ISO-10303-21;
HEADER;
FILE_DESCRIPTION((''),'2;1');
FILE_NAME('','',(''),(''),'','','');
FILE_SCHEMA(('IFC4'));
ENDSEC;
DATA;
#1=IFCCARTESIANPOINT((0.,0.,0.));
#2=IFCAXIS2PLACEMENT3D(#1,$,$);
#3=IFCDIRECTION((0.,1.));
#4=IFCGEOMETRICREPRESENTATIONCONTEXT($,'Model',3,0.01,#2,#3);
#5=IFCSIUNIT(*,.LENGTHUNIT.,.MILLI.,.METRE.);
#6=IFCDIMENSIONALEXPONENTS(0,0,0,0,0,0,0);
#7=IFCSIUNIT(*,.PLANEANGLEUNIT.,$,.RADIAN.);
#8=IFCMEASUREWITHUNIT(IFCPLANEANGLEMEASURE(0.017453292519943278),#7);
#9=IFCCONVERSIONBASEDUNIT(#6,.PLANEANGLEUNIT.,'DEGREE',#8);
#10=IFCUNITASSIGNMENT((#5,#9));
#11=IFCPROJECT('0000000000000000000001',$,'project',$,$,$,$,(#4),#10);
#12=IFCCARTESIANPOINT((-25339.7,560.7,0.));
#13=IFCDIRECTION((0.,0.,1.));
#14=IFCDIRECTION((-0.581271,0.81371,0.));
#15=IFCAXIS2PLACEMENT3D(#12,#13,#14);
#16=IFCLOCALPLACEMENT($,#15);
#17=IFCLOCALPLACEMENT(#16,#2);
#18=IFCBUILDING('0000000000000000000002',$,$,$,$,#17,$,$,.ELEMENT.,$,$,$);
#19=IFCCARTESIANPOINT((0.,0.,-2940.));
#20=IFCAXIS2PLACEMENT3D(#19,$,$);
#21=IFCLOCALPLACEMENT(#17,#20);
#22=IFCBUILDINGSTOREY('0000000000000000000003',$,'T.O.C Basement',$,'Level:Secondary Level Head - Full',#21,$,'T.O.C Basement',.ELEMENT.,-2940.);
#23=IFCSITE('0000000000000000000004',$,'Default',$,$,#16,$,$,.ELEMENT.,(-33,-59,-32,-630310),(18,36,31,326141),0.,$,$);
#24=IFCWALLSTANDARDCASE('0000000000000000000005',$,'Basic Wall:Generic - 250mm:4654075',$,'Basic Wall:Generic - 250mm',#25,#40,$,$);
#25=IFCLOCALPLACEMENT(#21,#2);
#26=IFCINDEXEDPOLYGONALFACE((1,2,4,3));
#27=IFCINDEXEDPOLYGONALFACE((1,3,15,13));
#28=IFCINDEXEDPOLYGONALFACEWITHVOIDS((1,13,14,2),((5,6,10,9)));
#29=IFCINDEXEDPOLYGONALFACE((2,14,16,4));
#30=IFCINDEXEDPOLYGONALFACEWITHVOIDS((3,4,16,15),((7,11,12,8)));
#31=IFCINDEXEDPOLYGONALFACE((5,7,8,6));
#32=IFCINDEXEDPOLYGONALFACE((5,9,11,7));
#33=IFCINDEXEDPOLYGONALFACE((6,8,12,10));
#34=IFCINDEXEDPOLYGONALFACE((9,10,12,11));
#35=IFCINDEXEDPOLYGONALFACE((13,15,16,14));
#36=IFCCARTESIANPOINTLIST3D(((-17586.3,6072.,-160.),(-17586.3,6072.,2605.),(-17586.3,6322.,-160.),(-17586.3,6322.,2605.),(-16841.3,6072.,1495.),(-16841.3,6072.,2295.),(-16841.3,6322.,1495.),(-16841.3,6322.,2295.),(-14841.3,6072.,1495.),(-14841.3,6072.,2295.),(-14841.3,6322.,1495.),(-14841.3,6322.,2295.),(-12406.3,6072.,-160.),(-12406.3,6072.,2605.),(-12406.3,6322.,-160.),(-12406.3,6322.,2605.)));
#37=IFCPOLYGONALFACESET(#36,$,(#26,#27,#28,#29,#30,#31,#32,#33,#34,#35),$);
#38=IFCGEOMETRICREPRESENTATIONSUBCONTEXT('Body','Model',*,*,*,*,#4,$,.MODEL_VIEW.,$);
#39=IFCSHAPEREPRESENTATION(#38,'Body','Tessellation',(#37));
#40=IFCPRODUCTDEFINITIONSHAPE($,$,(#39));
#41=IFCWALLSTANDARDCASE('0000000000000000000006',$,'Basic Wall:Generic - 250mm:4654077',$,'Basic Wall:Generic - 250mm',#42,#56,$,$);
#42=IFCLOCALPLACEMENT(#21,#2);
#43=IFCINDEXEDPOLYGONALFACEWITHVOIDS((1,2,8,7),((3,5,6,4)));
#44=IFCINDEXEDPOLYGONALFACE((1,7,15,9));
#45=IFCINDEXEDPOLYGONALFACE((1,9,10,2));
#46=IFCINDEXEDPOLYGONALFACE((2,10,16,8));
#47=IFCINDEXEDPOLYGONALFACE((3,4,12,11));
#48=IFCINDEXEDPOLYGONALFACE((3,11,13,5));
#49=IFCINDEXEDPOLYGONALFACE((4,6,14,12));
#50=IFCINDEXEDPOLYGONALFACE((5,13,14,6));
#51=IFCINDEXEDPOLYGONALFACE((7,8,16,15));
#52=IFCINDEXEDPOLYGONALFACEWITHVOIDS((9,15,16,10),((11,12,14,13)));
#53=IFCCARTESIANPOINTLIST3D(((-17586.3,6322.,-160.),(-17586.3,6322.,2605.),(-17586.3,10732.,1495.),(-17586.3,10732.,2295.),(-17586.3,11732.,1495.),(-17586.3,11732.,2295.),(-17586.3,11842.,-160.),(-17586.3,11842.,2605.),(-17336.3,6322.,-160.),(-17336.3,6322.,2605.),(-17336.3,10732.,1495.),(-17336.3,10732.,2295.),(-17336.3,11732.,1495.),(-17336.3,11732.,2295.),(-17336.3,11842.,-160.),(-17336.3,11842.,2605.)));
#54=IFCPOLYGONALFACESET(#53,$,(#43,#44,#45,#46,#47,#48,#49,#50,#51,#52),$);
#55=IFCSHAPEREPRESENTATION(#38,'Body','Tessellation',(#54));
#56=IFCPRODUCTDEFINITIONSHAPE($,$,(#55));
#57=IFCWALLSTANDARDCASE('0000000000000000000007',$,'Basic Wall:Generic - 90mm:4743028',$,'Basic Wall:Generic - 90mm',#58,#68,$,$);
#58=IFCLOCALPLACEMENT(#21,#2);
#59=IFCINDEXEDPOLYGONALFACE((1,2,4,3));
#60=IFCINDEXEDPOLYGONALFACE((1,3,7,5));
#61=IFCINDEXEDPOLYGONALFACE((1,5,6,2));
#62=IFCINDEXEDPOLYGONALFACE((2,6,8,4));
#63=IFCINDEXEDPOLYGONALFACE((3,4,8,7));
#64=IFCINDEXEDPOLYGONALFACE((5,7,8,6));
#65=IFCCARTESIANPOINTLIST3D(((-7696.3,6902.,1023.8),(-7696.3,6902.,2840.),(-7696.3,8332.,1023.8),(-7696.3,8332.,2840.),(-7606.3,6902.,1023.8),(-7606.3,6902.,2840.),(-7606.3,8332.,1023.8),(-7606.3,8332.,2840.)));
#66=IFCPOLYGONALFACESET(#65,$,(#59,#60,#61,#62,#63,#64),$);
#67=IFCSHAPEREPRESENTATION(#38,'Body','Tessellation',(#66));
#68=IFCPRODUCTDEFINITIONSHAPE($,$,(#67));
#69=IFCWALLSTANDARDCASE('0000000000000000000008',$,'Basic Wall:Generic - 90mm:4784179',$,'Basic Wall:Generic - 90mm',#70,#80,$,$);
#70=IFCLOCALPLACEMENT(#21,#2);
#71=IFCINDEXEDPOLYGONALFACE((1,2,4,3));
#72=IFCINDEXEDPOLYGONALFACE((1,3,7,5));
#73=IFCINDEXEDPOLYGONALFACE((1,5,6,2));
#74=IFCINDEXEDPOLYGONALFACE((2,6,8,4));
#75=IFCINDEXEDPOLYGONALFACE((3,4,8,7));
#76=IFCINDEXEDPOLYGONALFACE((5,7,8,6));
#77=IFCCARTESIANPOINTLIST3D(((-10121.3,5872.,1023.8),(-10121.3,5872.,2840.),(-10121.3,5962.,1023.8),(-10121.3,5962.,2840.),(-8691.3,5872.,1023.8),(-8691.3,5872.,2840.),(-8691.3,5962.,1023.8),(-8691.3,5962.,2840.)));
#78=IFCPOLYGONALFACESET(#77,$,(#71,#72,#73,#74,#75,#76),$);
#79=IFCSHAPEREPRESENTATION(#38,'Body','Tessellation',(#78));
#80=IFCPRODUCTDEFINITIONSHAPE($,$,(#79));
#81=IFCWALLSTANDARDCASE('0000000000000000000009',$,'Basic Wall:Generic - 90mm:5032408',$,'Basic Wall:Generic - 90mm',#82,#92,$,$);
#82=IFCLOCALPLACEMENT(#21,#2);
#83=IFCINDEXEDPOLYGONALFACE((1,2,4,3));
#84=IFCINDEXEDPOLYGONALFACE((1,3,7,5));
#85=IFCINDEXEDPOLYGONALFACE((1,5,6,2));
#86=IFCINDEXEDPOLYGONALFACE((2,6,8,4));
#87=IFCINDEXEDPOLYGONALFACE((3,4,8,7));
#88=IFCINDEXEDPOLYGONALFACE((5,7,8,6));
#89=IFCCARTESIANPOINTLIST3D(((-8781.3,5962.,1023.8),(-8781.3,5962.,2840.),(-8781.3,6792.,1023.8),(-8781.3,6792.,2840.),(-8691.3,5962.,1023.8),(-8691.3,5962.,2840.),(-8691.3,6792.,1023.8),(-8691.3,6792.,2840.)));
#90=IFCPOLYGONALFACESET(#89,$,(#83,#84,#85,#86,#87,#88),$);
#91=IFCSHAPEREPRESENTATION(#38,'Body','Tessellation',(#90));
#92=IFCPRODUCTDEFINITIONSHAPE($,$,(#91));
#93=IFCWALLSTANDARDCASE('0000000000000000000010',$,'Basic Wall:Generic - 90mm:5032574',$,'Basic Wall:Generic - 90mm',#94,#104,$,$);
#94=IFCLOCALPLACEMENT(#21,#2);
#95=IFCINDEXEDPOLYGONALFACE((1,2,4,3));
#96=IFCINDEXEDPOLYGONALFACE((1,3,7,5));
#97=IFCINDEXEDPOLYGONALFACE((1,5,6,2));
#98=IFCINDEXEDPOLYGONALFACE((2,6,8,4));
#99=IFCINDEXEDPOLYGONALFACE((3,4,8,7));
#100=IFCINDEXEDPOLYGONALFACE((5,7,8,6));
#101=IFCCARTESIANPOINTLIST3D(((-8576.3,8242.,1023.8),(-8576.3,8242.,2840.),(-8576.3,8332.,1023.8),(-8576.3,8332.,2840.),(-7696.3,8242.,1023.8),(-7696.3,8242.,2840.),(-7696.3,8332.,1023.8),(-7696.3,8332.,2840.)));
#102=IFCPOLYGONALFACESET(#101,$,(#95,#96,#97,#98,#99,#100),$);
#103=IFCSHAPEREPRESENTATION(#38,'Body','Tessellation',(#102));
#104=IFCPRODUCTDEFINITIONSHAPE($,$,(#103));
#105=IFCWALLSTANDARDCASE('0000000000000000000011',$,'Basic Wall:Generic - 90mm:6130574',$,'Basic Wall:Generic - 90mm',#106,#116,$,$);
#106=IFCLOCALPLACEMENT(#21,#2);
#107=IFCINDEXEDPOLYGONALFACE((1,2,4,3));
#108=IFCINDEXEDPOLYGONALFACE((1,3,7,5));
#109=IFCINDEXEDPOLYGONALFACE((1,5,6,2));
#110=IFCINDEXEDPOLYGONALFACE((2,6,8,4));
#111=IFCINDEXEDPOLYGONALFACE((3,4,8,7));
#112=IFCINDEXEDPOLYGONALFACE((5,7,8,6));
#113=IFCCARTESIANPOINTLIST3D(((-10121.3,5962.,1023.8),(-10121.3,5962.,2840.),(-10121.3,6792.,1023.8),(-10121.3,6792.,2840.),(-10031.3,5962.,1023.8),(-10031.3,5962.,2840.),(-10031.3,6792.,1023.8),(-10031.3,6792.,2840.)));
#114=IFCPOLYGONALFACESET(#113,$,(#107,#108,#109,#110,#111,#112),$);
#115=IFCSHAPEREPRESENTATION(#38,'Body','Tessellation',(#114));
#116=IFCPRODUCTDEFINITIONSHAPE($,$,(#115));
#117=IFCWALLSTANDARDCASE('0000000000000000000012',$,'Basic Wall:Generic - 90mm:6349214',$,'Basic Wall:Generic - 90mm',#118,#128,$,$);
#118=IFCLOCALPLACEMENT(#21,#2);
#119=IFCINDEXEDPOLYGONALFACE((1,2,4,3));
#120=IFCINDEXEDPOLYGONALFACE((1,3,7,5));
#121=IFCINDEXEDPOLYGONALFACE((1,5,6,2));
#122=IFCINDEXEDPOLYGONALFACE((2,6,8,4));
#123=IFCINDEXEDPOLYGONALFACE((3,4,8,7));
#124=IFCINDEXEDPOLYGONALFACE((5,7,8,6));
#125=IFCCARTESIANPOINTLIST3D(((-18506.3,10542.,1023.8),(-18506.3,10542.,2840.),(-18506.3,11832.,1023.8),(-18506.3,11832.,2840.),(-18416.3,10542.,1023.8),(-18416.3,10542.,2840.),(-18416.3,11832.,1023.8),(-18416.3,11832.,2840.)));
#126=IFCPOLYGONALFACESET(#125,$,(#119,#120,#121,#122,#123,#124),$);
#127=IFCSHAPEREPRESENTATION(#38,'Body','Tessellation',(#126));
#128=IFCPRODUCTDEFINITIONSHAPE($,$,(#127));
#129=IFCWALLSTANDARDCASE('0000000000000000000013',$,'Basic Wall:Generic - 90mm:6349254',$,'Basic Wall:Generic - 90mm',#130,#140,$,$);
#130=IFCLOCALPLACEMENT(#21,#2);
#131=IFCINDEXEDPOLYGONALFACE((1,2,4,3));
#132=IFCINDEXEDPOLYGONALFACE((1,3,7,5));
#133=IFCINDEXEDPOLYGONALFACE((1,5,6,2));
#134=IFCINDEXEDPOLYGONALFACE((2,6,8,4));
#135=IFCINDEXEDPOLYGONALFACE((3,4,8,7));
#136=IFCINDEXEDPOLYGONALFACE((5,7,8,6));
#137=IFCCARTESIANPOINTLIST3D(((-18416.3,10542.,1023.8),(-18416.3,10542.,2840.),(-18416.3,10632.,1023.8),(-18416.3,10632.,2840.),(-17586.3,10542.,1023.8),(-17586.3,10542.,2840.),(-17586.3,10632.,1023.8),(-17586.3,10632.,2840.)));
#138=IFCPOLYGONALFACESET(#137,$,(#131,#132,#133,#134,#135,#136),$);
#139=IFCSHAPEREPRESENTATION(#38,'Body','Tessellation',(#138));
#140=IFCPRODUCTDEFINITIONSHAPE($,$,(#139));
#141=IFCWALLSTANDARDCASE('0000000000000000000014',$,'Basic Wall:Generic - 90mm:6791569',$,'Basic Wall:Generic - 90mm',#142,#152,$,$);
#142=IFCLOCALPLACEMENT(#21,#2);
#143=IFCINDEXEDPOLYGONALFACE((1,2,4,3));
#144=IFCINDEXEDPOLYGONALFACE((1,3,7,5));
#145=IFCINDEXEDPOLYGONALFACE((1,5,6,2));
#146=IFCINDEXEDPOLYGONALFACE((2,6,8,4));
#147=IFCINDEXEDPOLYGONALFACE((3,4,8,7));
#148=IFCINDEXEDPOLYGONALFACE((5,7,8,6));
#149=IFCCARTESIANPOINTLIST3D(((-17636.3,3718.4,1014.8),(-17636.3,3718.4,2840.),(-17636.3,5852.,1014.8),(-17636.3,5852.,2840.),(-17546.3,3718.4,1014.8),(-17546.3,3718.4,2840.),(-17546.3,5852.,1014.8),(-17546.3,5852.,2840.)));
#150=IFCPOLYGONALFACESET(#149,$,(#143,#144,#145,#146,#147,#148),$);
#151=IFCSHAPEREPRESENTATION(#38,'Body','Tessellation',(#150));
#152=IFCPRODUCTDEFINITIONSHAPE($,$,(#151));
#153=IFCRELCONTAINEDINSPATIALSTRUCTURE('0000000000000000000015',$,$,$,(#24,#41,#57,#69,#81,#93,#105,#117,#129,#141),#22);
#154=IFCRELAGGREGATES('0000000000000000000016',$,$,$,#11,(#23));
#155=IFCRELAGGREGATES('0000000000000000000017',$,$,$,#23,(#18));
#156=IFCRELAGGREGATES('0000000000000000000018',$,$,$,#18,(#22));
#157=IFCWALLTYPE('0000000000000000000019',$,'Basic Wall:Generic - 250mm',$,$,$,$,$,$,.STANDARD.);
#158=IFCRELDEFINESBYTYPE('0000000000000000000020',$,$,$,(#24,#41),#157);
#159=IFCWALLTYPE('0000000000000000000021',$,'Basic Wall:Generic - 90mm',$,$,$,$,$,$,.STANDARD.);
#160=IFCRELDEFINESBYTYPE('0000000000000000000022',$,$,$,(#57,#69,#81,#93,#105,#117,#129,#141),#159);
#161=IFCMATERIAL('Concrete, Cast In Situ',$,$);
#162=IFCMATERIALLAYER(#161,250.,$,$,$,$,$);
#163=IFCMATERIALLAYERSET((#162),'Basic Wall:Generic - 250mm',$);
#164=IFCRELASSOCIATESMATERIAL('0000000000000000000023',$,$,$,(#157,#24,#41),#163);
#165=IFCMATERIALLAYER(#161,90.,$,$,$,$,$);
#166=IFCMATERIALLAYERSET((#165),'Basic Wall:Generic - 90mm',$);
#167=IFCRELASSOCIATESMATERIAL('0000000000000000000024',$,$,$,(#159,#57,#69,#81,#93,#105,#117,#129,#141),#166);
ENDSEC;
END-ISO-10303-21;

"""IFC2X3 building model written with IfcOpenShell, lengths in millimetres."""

from ifc_helpers import new_model, entity, si_unit, converted_unit, direction, frame, frame_2d, origin, place, context, subcontext, project, spatial, polyline, rectangle, extrude, clip, bounded_halfspace, material, layer, layer_set, layer_usage, type_object, element, save


model = new_model("IFC2X3")

# Units and contexts
model_context = context("Model", 3, precision=0.01, world=origin(), true_north=direction((0.0, 1.0)))
body_context = subcontext(model_context, "Body", "Model", "MODEL_VIEW")
ifc_project = project(units=[si_unit("LENGTHUNIT", "METRE", prefix="MILLI"), converted_unit("PLANEANGLEUNIT", "DEGREE", entity("IfcPlaneAngleMeasure", 0.017453292519943278), si_unit("PLANEANGLEUNIT", "RADIAN"), dimensions=[0, 0, 0, 0, 0, 0, 0])], contexts=[model_context])

# Site, building, storey
site_placement = place(None, frame((-25339.7, 560.7, 0.0), z_axis=(0.0, 0.0, 1.0), x_axis=(-0.581271, 0.81371, 0.0)))
site = spatial("IfcSite", under=ifc_project, at=site_placement, Name="Default", CompositionType="ELEMENT", RefLatitude=(-33, -59, -32, -630310), RefLongitude=(18, 36, 31, 326141), RefElevation=0.0)
building_placement = place(site_placement, origin())
building = spatial("IfcBuilding", under=site, at=building_placement, CompositionType="ELEMENT")
storey_placement = place(building_placement, frame((0.0, 0.0, -2940.0)))
storey = spatial("IfcBuildingStorey", under=building, at=storey_placement, Name="T.O.C Basement", ObjectType="Level:Secondary Level Head - Full", LongName="T.O.C Basement", CompositionType="ELEMENT", Elevation=-2940.0)

# Shared definitions
ifc_material_1 = material(Name="Concrete, Cast In Situ")

# Shared definitions
ifc_layer_1 = layer(ifc_material_1, 250.0)
ifc_layer_set_1 = layer_set([ifc_layer_1], Name="Basic Wall:Generic - 250mm")
wall_type_1 = type_object("IfcWallType", Name="Basic Wall:Generic - 250mm", PredefinedType="STANDARD", material=ifc_layer_set_1)

# Walls, openings
ifc_layer_usage_1 = layer_usage(ifc_layer_set_1, "AXIS2", "NEGATIVE", 125.0)
wall_1_placement = place(storey_placement, frame((-12406.3, 6197.0, -160.0), z_axis=(0.0, 0.0, 1.0), x_axis=(-1.0, 0.0, 0.0)))
wall_1 = element("IfcWallStandardCase", 1, at=wall_1_placement, inside=storey, type_object=wall_type_1, material=ifc_layer_usage_1, Name="Basic Wall:Generic - 250mm:4654075", ObjectType="Basic Wall:Generic - 250mm", context=body_context, shape_type="Clipping", body=[
    clip(extrude(rectangle(XDim=5180.0, YDim=250.0, at=frame_2d((2590.0, 0.0), x_axis=(-1.0, 0.0))), origin(), (0.0, 0.0, 1.0), 2765.0), bounded_halfspace(frame((0.0, -125.0, 2765.0), z_axis=(0.0, 0.0, -1.0), x_axis=(-1.0, 0.0, 0.0)), True, frame((0.0, -125.0, 2765.0)), polyline([(0.0, 0.0), (4930.0, 0.0), (5180.0, 0.0), (5180.0, 250.0), (0.0, 250.0), (0.0, 0.0)]))),
])
opening_1_placement = place(wall_1_placement, origin())
element("IfcOpeningElement", 2, at=opening_1_placement, cuts=wall_1, ObjectType="Opening", context=body_context, shape_type="SweptSolid", body=[
    extrude(rectangle(XDim=800.0, YDim=2000.0, at=frame_2d((0.0, 0.0), x_axis=(1.0, 0.0))), frame((3435.0, -125.0, 2055.0), z_axis=(0.0, 1.0, 0.0), x_axis=(0.0, 0.0, -1.0)), (0.0, 0.0, 1.0), 250.0),
])
ifc_layer_usage_2 = layer_usage(ifc_layer_set_1, "AXIS2", "NEGATIVE", 125.0)
wall_2_placement = place(storey_placement, frame((-17461.3, 6322.0, -160.0), z_axis=(0.0, 0.0, 1.0), x_axis=(0.0, 1.0, 0.0)))
wall_2 = element("IfcWallStandardCase", 3, at=wall_2_placement, inside=storey, type_object=wall_type_1, material=ifc_layer_usage_2, Name="Basic Wall:Generic - 250mm:4654077", ObjectType="Basic Wall:Generic - 250mm", context=body_context, shape_type="Clipping", body=[
    clip(extrude(rectangle(XDim=5520.0, YDim=250.0, at=frame_2d((2760.0, 0.0), x_axis=(-1.0, 0.0))), origin(), (0.0, 0.0, 1.0), 2765.0), bounded_halfspace(frame((0.0, -125.0, 2765.0), z_axis=(0.0, 0.0, -1.0), x_axis=(0.0, -1.0, 0.0)), True, frame((0.0, -125.0, 2765.0)), polyline([(0.0, 0.0), (5520.0, 0.0), (5520.0, 250.0), (5510.0, 250.0), (0.0, 250.0), (0.0, 0.0)]))),
])
opening_2_placement = place(wall_2_placement, origin())
element("IfcOpeningElement", 4, at=opening_2_placement, cuts=wall_2, ObjectType="Opening", context=body_context, shape_type="SweptSolid", body=[
    extrude(rectangle(XDim=800.0, YDim=1000.0, at=frame_2d((0.0, 0.0), x_axis=(1.0, 0.0))), frame((4910.0, -125.0, 2055.0), z_axis=(0.0, 1.0, 0.0), x_axis=(0.0, 0.0, -1.0)), (0.0, 0.0, 1.0), 250.0),
])

# Walls
ifc_layer_2 = layer(ifc_material_1, 90.0)
ifc_layer_set_2 = layer_set([ifc_layer_2], Name="Basic Wall:Generic - 90mm")
ifc_layer_usage_3 = layer_usage(ifc_layer_set_2, "AXIS2", "NEGATIVE", 45.0)
wall_type_2 = type_object("IfcWallType", Name="Basic Wall:Generic - 90mm", PredefinedType="STANDARD", material=ifc_layer_set_2)
wall_3_placement = place(storey_placement, frame((-7651.3, 8332.0, 1023.8), z_axis=(0.0, 0.0, 1.0), x_axis=(0.0, -1.0, 0.0)))
element("IfcWallStandardCase", 5, at=wall_3_placement, inside=storey, type_object=wall_type_2, material=ifc_layer_usage_3, Name="Basic Wall:Generic - 90mm:4743028", ObjectType="Basic Wall:Generic - 90mm", context=body_context, shape_type="SweptSolid", body=[
    extrude(rectangle(XDim=1430.0, YDim=90.0, at=frame_2d((715.0, 0.0), x_axis=(-1.0, 0.0))), origin(), (0.0, 0.0, 1.0), 1816.2),
])
ifc_layer_usage_4 = layer_usage(ifc_layer_set_2, "AXIS2", "NEGATIVE", 45.0)
wall_4_placement = place(storey_placement, frame((-10121.3, 5917.0, 1023.8)))
element("IfcWallStandardCase", 6, at=wall_4_placement, inside=storey, type_object=wall_type_2, material=ifc_layer_usage_4, Name="Basic Wall:Generic - 90mm:4784179", ObjectType="Basic Wall:Generic - 90mm", context=body_context, shape_type="SweptSolid", body=[
    extrude(rectangle(XDim=1430.0, YDim=90.0, at=frame_2d((715.0, 0.0), x_axis=(-1.0, 0.0))), origin(), (0.0, 0.0, 1.0), 1816.2),
])
ifc_layer_usage_5 = layer_usage(ifc_layer_set_2, "AXIS2", "NEGATIVE", 45.0)
wall_5_placement = place(storey_placement, frame((-8736.3, 5962.0, 1023.8), z_axis=(0.0, 0.0, 1.0), x_axis=(0.0, 1.0, 0.0)))
element("IfcWallStandardCase", 7, at=wall_5_placement, inside=storey, type_object=wall_type_2, material=ifc_layer_usage_5, Name="Basic Wall:Generic - 90mm:5032408", ObjectType="Basic Wall:Generic - 90mm", context=body_context, shape_type="SweptSolid", body=[
    extrude(rectangle(XDim=830.0, YDim=90.0, at=frame_2d((415.0, 0.0), x_axis=(-1.0, 0.0))), origin(), (0.0, 0.0, 1.0), 1816.2),
])
ifc_layer_usage_6 = layer_usage(ifc_layer_set_2, "AXIS2", "NEGATIVE", 45.0)
wall_6_placement = place(storey_placement, frame((-7696.3, 8287.0, 1023.8), z_axis=(0.0, 0.0, 1.0), x_axis=(-1.0, 0.0, 0.0)))
element("IfcWallStandardCase", 8, at=wall_6_placement, inside=storey, type_object=wall_type_2, material=ifc_layer_usage_6, Name="Basic Wall:Generic - 90mm:5032574", ObjectType="Basic Wall:Generic - 90mm", context=body_context, shape_type="SweptSolid", body=[
    extrude(rectangle(XDim=880.0, YDim=90.0, at=frame_2d((440.0, 0.0), x_axis=(-1.0, 0.0))), origin(), (0.0, 0.0, 1.0), 1816.2),
])
ifc_layer_usage_7 = layer_usage(ifc_layer_set_2, "AXIS2", "NEGATIVE", 45.0)
wall_7_placement = place(storey_placement, frame((-10076.3, 5962.0, 1023.8), z_axis=(0.0, 0.0, 1.0), x_axis=(0.0, 1.0, 0.0)))
element("IfcWallStandardCase", 9, at=wall_7_placement, inside=storey, type_object=wall_type_2, material=ifc_layer_usage_7, Name="Basic Wall:Generic - 90mm:6130574", ObjectType="Basic Wall:Generic - 90mm", context=body_context, shape_type="SweptSolid", body=[
    extrude(rectangle(XDim=830.0, YDim=90.0, at=frame_2d((415.0, 0.0), x_axis=(-1.0, 0.0))), origin(), (0.0, 0.0, 1.0), 1816.2),
])
ifc_layer_usage_8 = layer_usage(ifc_layer_set_2, "AXIS2", "NEGATIVE", 45.0)
wall_8_placement = place(storey_placement, frame((-18461.3, 11832.0, 1023.8), z_axis=(0.0, 0.0, 1.0), x_axis=(0.0, -1.0, 0.0)))
element("IfcWallStandardCase", 10, at=wall_8_placement, inside=storey, type_object=wall_type_2, material=ifc_layer_usage_8, Name="Basic Wall:Generic - 90mm:6349214", ObjectType="Basic Wall:Generic - 90mm", context=body_context, shape_type="SweptSolid", body=[
    extrude(rectangle(XDim=1290.0, YDim=90.0, at=frame_2d((645.0, 0.0), x_axis=(-1.0, 0.0))), origin(), (0.0, 0.0, 1.0), 1816.2),
])
ifc_layer_usage_9 = layer_usage(ifc_layer_set_2, "AXIS2", "NEGATIVE", 45.0)
wall_9_placement = place(storey_placement, frame((-18416.3, 10587.0, 1023.8)))
element("IfcWallStandardCase", 11, at=wall_9_placement, inside=storey, type_object=wall_type_2, material=ifc_layer_usage_9, Name="Basic Wall:Generic - 90mm:6349254", ObjectType="Basic Wall:Generic - 90mm", context=body_context, shape_type="SweptSolid", body=[
    extrude(rectangle(XDim=830.0, YDim=90.0, at=frame_2d((415.0, 0.0), x_axis=(-1.0, 0.0))), origin(), (0.0, 0.0, 1.0), 1816.2),
])
ifc_layer_usage_10 = layer_usage(ifc_layer_set_2, "AXIS2", "NEGATIVE", 45.0)
wall_10_placement = place(storey_placement, frame((-17591.3, 5852.0, 1014.8), z_axis=(0.0, 0.0, 1.0), x_axis=(0.0, -1.0, 0.0)))
element("IfcWallStandardCase", 12, at=wall_10_placement, inside=storey, type_object=wall_type_2, material=ifc_layer_usage_10, Name="Basic Wall:Generic - 90mm:6791569", ObjectType="Basic Wall:Generic - 90mm", context=body_context, shape_type="SweptSolid", body=[
    extrude(rectangle(XDim=2133.7, YDim=90.0, at=frame_2d((1066.8, 0.0), x_axis=(-1.0, 0.0))), origin(), (0.0, 0.0, 1.0), 1825.2),
])

save(model, "model.ifc")
